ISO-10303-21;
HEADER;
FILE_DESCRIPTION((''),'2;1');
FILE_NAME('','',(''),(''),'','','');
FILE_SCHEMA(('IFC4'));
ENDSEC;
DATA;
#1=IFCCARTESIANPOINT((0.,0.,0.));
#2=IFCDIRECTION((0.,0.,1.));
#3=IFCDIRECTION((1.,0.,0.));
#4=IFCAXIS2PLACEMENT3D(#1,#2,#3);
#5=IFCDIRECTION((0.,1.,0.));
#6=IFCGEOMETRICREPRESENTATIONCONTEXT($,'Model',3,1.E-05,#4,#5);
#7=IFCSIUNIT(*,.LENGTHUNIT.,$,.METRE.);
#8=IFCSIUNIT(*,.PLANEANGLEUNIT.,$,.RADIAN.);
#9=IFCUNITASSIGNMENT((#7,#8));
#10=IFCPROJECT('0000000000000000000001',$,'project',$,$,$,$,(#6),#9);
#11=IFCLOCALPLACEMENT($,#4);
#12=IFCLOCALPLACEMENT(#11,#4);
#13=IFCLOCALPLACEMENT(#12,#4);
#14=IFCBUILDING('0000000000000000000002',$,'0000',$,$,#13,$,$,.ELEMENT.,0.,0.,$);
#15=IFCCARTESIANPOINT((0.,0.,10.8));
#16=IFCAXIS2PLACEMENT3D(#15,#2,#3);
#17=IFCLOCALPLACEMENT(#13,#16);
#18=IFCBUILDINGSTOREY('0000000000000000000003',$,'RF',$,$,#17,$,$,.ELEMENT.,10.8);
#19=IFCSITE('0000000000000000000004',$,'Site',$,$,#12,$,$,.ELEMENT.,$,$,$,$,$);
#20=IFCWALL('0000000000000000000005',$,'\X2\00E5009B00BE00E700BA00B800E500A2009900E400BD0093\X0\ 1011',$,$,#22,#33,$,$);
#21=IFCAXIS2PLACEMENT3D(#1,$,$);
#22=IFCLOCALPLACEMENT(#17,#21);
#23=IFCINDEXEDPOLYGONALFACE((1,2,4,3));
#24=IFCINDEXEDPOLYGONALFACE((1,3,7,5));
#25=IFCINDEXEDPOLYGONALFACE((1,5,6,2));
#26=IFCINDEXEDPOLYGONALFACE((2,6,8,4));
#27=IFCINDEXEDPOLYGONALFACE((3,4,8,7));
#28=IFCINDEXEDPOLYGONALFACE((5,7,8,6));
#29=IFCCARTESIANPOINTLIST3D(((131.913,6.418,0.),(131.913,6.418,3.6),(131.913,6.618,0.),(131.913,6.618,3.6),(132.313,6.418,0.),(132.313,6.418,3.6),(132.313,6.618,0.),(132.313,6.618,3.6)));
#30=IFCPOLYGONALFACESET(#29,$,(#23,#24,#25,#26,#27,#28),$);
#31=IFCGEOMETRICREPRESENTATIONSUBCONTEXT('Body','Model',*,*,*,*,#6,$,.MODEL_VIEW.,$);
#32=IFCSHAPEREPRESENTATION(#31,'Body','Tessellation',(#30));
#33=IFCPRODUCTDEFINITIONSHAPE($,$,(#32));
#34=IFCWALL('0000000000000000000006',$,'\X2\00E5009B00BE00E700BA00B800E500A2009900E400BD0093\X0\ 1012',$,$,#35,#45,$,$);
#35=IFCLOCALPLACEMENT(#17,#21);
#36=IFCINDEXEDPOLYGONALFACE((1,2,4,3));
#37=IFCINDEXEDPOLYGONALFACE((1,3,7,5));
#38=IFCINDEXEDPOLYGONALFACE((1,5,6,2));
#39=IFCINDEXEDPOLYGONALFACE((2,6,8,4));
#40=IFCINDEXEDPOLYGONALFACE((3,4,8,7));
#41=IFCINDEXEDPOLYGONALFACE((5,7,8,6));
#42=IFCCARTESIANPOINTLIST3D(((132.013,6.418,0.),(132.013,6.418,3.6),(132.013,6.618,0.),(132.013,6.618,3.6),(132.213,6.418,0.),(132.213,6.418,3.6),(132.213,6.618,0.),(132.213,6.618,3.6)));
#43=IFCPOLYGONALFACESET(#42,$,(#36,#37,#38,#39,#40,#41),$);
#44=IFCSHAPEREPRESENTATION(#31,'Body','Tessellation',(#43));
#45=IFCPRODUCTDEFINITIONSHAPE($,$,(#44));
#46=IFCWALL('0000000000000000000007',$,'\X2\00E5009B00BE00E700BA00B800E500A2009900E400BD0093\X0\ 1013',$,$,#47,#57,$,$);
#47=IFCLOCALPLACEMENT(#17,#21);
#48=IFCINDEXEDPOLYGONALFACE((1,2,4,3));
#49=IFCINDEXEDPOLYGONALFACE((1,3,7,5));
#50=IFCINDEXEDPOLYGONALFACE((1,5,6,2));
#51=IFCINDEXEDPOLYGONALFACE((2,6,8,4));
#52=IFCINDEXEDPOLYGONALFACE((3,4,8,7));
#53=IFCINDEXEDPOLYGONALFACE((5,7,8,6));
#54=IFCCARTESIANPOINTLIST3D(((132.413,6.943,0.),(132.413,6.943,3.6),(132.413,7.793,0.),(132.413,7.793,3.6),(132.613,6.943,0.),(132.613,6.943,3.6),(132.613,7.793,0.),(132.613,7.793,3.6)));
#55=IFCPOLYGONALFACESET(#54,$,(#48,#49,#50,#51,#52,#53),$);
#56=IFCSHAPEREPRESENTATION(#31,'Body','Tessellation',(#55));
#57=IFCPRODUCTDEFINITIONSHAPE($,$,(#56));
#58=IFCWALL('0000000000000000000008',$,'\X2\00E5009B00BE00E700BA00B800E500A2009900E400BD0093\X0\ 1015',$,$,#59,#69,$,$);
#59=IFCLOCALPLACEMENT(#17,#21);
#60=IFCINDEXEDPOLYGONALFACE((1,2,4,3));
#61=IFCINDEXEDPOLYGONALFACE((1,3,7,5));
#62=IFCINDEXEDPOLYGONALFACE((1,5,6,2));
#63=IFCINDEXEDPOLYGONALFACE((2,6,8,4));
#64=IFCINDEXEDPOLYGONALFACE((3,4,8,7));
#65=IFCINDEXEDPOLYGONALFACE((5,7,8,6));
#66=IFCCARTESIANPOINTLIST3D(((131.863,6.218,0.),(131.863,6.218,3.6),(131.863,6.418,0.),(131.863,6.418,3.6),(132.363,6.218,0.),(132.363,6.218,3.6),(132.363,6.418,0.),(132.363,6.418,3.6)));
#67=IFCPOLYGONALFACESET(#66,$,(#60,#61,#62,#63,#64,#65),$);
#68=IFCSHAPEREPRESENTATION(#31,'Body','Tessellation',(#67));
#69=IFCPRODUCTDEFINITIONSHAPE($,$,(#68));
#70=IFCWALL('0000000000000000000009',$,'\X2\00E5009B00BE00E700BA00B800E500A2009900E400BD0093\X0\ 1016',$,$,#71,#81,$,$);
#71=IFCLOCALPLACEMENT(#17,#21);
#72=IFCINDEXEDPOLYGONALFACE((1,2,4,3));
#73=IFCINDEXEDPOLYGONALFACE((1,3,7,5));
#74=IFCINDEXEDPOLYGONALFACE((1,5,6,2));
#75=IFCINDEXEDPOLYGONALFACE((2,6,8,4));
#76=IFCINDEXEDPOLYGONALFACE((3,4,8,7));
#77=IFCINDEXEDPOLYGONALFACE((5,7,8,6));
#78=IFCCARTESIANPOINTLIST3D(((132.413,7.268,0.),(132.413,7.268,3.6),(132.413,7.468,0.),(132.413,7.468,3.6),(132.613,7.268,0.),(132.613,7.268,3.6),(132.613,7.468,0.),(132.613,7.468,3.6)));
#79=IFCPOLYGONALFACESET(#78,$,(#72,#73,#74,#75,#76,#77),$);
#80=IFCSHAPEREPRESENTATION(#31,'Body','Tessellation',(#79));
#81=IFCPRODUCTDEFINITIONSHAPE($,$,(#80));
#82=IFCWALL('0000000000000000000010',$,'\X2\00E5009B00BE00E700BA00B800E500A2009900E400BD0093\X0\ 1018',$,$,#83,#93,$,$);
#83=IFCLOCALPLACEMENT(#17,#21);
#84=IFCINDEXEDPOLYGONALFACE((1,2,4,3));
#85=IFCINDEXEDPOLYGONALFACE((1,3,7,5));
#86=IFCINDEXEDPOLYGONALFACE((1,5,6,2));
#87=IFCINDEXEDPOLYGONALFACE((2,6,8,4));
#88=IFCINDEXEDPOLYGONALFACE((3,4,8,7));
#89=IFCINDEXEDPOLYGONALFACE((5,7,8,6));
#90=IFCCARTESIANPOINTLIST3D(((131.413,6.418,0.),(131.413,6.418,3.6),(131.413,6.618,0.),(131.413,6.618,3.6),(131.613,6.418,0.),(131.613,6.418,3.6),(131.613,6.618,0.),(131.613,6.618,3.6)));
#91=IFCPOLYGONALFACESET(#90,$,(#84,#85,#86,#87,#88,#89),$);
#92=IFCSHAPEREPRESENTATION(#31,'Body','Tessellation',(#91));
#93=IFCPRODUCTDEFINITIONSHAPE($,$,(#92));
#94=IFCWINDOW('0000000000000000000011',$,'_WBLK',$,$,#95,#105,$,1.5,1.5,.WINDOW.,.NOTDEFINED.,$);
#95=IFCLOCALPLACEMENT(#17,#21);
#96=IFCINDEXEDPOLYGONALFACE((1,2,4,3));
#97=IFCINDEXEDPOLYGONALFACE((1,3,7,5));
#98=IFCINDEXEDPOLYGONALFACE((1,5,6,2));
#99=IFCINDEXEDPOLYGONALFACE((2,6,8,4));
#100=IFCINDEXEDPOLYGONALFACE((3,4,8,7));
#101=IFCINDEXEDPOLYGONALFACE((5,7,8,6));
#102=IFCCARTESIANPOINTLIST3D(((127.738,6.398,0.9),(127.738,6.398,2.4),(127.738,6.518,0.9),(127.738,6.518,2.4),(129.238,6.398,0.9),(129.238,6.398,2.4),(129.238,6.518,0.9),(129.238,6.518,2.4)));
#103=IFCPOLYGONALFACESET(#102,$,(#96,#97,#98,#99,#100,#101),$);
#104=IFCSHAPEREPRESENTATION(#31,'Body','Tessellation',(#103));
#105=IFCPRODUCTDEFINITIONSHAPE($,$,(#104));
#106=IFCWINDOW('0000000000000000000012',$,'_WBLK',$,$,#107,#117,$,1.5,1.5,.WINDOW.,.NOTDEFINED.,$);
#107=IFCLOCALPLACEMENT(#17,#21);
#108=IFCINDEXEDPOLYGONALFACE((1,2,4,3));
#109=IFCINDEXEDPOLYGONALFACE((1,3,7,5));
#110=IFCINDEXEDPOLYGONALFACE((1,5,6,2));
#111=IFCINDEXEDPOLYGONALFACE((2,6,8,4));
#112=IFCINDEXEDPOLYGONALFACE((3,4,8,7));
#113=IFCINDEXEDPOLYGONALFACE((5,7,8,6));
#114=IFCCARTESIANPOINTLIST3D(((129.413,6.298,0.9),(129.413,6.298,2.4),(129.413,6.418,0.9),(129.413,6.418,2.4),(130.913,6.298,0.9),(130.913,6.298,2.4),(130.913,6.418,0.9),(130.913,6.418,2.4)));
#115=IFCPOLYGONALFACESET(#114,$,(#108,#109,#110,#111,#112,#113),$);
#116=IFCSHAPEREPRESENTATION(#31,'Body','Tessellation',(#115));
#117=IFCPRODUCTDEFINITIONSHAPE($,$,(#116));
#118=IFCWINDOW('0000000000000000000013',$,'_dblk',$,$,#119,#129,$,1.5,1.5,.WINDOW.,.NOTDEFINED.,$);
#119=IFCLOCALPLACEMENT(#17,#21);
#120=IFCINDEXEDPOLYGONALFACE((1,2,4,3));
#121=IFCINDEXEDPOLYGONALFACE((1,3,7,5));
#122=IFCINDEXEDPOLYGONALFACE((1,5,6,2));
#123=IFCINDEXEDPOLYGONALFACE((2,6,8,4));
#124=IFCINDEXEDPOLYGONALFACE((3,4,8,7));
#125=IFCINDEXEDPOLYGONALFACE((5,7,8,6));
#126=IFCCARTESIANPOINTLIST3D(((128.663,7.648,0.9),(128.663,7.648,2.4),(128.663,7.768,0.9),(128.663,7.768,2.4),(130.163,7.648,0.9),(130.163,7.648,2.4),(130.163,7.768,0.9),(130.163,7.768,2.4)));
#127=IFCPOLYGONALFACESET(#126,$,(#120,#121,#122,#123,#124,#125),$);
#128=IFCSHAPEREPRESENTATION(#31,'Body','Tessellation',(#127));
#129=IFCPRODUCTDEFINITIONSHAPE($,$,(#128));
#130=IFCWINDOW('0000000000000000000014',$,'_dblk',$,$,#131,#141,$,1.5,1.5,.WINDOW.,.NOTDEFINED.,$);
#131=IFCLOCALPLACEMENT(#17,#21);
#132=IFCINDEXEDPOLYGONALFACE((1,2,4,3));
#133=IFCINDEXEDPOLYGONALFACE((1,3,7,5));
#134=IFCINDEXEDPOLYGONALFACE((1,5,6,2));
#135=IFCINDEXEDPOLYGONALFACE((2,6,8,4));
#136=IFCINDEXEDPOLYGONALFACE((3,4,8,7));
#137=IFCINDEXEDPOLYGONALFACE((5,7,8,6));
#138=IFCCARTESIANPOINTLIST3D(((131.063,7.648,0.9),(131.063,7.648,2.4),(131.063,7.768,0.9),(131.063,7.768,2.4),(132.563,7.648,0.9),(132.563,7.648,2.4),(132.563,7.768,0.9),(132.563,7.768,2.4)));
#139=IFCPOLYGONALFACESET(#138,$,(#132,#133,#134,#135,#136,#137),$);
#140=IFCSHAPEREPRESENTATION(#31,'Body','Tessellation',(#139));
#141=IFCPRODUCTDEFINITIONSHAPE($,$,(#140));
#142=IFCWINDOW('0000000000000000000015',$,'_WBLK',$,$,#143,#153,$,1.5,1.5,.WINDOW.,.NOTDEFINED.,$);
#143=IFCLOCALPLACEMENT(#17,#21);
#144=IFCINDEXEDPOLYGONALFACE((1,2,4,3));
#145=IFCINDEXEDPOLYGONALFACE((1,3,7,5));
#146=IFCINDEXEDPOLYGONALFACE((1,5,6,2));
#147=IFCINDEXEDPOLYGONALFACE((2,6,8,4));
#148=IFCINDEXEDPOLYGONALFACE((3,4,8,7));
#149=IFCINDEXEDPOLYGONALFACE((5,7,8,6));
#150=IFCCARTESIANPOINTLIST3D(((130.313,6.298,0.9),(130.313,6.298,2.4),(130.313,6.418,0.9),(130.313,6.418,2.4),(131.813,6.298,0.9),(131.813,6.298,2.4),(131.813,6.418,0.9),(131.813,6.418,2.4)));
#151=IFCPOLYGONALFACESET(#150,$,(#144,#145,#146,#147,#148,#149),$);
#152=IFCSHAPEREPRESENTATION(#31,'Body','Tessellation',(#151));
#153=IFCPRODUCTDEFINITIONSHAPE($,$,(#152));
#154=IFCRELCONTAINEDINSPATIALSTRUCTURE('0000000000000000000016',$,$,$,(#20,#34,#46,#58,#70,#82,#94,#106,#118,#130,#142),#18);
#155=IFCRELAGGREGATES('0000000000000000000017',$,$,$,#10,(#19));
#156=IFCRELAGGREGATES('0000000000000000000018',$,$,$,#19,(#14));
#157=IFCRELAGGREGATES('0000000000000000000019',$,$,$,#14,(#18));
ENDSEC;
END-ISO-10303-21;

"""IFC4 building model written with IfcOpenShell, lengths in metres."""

from ifc_helpers import new_model, si_unit, direction, frame, frame_2d, origin_with_axes, place, context, subcontext, project, spatial, rectangle, extrude, element, save


model = new_model("IFC4")

# Units and contexts
model_context = context("Model", 3, precision=1e-05, world=origin_with_axes(), true_north=direction((0.0, 1.0, 0.0)))
body_context = subcontext(model_context, "Body", "Model", "MODEL_VIEW")
ifc_project = project(units=[si_unit("LENGTHUNIT", "METRE"), si_unit("PLANEANGLEUNIT", "RADIAN")], contexts=[model_context])

# Site, building, storey
placement = place(None, origin_with_axes())
site_placement = place(placement, origin_with_axes())
site = spatial("IfcSite", under=ifc_project, at=site_placement, Name="Site", CompositionType="ELEMENT")
building_placement = place(site_placement, origin_with_axes())
building = spatial("IfcBuilding", under=site, at=building_placement, Name="0000", CompositionType="ELEMENT", ElevationOfRefHeight=0.0, ElevationOfTerrain=0.0)
storey_placement = place(building_placement, frame((0.0, 0.0, 10.8), z_axis=(0.0, 0.0, 1.0), x_axis=(1.0, 0.0, 0.0)))
storey = spatial("IfcBuildingStorey", under=building, at=storey_placement, Name="RF", CompositionType="ELEMENT", Elevation=10.8)

# Walls
for number, where, z_axis, x_axis, name in (
    (1, (132.113, 6.518, 0.0), (0.0, 0.0, 1.0), (1.0, 0.0, 0.0), "å\u009b¾çº¸å¢\u0099ä½\u0093 1011"),
):
    element("IfcWall", number, at=place(storey_placement, frame(where, z_axis=z_axis, x_axis=x_axis)), inside=storey, Name=name, context=body_context, shape_type="SweptSolid", body=[
        extrude(rectangle(XDim=0.4, YDim=0.2, at=frame_2d((0.0, 0.0), x_axis=(1.0, 0.0, 0.0))), frame((0.0, 0.0, 0.0), z_axis=(0.0, 0.0, 1.0)), (0.0, 0.0, 1.0), 3.6),
    ])
wall_1_placement = place(storey_placement, frame((132.113, 6.518, 0.0), z_axis=(0.0, 0.0, 1.0), x_axis=(0.0, -1.0, 0.0)))
element("IfcWall", 2, at=wall_1_placement, inside=storey, Name="å\u009b¾çº¸å¢\u0099ä½\u0093 1012", context=body_context, shape_type="SweptSolid", body=[
    extrude(rectangle(XDim=0.2, YDim=0.2, at=frame_2d((0.0, 0.0), x_axis=(1.0, 0.0, 0.0))), frame((0.0, 0.0, 0.0), z_axis=(0.0, 0.0, 1.0)), (0.0, 0.0, 1.0), 3.6),
])
wall_2_placement = place(storey_placement, frame((132.513, 7.368, 0.0), z_axis=(0.0, 0.0, 1.0), x_axis=(0.0, -1.0, 0.0)))
element("IfcWall", 3, at=wall_2_placement, inside=storey, Name="å\u009b¾çº¸å¢\u0099ä½\u0093 1013", context=body_context, shape_type="SweptSolid", body=[
    extrude(rectangle(XDim=0.85, YDim=0.2, at=frame_2d((0.0, 0.0), x_axis=(1.0, 0.0, 0.0))), frame((0.0, 0.0, 0.0), z_axis=(0.0, 0.0, 1.0)), (0.0, 0.0, 1.0), 3.6),
])
wall_3_placement = place(storey_placement, frame((132.113, 6.318, 0.0), z_axis=(0.0, 0.0, 1.0), x_axis=(1.0, 0.0, 0.0)))
element("IfcWall", 4, at=wall_3_placement, inside=storey, Name="å\u009b¾çº¸å¢\u0099ä½\u0093 1015", context=body_context, shape_type="SweptSolid", body=[
    extrude(rectangle(XDim=0.5, YDim=0.2, at=frame_2d((0.0, 0.0), x_axis=(1.0, 0.0, 0.0))), frame((0.0, 0.0, 0.0), z_axis=(0.0, 0.0, 1.0)), (0.0, 0.0, 1.0), 3.6),
])
for number, where, z_axis, x_axis, name in (
    (5, (132.513, 7.368, 0.0), (0.0, 0.0, 1.0), (1.0, 0.0, 0.0), "å\u009b¾çº¸å¢\u0099ä½\u0093 1016"),
    (6, (131.513, 6.518, 0.0), (0.0, 0.0, 1.0), (0.0, -1.0, 0.0), "å\u009b¾çº¸å¢\u0099ä½\u0093 1018"),
):
    element("IfcWall", number, at=place(storey_placement, frame(where, z_axis=z_axis, x_axis=x_axis)), inside=storey, Name=name, context=body_context, shape_type="SweptSolid", body=[
        extrude(rectangle(XDim=0.2, YDim=0.2, at=frame_2d((0.0, 0.0), x_axis=(1.0, 0.0, 0.0))), frame((0.0, 0.0, 0.0), z_axis=(0.0, 0.0, 1.0)), (0.0, 0.0, 1.0), 3.6),
    ])

# Windows
for number, where, z_axis, x_axis, name in (
    (7, (128.488, 6.458, 0.9), (0.0, 0.0, 1.0), (1.0, 0.0, 0.0), "_WBLK"),
    (8, (130.163, 6.358, 0.9), (0.0, 0.0, 1.0), (1.0, 0.0, 0.0), "_WBLK"),
    (9, (129.413, 7.708, 0.9), (0.0, 0.0, 1.0), (1.0, 0.0, 0.0), "_dblk"),
    (10, (131.813, 7.708, 0.9), (0.0, 0.0, 1.0), (1.0, 0.0, 0.0), "_dblk"),
    (11, (131.063, 6.358, 0.9), (0.0, 0.0, 1.0), (1.0, 0.0, 0.0), "_WBLK"),
):
    element("IfcWindow", number, at=place(storey_placement, frame(where, z_axis=z_axis, x_axis=x_axis)), inside=storey, Name=name, OverallHeight=1.5, OverallWidth=1.5, PartitioningType="NOTDEFINED", PredefinedType="WINDOW", context=body_context, shape_type="SweptSolid", body=[
        extrude(rectangle(XDim=1.5, YDim=0.12, at=frame_2d((0.0, 0.0), x_axis=(1.0, 0.0, 0.0))), frame((0.0, 0.0, 0.0), z_axis=(0.0, 0.0, 1.0)), (0.0, 0.0, 1.0), 1.5),
    ])

save(model, "model.ifc")
